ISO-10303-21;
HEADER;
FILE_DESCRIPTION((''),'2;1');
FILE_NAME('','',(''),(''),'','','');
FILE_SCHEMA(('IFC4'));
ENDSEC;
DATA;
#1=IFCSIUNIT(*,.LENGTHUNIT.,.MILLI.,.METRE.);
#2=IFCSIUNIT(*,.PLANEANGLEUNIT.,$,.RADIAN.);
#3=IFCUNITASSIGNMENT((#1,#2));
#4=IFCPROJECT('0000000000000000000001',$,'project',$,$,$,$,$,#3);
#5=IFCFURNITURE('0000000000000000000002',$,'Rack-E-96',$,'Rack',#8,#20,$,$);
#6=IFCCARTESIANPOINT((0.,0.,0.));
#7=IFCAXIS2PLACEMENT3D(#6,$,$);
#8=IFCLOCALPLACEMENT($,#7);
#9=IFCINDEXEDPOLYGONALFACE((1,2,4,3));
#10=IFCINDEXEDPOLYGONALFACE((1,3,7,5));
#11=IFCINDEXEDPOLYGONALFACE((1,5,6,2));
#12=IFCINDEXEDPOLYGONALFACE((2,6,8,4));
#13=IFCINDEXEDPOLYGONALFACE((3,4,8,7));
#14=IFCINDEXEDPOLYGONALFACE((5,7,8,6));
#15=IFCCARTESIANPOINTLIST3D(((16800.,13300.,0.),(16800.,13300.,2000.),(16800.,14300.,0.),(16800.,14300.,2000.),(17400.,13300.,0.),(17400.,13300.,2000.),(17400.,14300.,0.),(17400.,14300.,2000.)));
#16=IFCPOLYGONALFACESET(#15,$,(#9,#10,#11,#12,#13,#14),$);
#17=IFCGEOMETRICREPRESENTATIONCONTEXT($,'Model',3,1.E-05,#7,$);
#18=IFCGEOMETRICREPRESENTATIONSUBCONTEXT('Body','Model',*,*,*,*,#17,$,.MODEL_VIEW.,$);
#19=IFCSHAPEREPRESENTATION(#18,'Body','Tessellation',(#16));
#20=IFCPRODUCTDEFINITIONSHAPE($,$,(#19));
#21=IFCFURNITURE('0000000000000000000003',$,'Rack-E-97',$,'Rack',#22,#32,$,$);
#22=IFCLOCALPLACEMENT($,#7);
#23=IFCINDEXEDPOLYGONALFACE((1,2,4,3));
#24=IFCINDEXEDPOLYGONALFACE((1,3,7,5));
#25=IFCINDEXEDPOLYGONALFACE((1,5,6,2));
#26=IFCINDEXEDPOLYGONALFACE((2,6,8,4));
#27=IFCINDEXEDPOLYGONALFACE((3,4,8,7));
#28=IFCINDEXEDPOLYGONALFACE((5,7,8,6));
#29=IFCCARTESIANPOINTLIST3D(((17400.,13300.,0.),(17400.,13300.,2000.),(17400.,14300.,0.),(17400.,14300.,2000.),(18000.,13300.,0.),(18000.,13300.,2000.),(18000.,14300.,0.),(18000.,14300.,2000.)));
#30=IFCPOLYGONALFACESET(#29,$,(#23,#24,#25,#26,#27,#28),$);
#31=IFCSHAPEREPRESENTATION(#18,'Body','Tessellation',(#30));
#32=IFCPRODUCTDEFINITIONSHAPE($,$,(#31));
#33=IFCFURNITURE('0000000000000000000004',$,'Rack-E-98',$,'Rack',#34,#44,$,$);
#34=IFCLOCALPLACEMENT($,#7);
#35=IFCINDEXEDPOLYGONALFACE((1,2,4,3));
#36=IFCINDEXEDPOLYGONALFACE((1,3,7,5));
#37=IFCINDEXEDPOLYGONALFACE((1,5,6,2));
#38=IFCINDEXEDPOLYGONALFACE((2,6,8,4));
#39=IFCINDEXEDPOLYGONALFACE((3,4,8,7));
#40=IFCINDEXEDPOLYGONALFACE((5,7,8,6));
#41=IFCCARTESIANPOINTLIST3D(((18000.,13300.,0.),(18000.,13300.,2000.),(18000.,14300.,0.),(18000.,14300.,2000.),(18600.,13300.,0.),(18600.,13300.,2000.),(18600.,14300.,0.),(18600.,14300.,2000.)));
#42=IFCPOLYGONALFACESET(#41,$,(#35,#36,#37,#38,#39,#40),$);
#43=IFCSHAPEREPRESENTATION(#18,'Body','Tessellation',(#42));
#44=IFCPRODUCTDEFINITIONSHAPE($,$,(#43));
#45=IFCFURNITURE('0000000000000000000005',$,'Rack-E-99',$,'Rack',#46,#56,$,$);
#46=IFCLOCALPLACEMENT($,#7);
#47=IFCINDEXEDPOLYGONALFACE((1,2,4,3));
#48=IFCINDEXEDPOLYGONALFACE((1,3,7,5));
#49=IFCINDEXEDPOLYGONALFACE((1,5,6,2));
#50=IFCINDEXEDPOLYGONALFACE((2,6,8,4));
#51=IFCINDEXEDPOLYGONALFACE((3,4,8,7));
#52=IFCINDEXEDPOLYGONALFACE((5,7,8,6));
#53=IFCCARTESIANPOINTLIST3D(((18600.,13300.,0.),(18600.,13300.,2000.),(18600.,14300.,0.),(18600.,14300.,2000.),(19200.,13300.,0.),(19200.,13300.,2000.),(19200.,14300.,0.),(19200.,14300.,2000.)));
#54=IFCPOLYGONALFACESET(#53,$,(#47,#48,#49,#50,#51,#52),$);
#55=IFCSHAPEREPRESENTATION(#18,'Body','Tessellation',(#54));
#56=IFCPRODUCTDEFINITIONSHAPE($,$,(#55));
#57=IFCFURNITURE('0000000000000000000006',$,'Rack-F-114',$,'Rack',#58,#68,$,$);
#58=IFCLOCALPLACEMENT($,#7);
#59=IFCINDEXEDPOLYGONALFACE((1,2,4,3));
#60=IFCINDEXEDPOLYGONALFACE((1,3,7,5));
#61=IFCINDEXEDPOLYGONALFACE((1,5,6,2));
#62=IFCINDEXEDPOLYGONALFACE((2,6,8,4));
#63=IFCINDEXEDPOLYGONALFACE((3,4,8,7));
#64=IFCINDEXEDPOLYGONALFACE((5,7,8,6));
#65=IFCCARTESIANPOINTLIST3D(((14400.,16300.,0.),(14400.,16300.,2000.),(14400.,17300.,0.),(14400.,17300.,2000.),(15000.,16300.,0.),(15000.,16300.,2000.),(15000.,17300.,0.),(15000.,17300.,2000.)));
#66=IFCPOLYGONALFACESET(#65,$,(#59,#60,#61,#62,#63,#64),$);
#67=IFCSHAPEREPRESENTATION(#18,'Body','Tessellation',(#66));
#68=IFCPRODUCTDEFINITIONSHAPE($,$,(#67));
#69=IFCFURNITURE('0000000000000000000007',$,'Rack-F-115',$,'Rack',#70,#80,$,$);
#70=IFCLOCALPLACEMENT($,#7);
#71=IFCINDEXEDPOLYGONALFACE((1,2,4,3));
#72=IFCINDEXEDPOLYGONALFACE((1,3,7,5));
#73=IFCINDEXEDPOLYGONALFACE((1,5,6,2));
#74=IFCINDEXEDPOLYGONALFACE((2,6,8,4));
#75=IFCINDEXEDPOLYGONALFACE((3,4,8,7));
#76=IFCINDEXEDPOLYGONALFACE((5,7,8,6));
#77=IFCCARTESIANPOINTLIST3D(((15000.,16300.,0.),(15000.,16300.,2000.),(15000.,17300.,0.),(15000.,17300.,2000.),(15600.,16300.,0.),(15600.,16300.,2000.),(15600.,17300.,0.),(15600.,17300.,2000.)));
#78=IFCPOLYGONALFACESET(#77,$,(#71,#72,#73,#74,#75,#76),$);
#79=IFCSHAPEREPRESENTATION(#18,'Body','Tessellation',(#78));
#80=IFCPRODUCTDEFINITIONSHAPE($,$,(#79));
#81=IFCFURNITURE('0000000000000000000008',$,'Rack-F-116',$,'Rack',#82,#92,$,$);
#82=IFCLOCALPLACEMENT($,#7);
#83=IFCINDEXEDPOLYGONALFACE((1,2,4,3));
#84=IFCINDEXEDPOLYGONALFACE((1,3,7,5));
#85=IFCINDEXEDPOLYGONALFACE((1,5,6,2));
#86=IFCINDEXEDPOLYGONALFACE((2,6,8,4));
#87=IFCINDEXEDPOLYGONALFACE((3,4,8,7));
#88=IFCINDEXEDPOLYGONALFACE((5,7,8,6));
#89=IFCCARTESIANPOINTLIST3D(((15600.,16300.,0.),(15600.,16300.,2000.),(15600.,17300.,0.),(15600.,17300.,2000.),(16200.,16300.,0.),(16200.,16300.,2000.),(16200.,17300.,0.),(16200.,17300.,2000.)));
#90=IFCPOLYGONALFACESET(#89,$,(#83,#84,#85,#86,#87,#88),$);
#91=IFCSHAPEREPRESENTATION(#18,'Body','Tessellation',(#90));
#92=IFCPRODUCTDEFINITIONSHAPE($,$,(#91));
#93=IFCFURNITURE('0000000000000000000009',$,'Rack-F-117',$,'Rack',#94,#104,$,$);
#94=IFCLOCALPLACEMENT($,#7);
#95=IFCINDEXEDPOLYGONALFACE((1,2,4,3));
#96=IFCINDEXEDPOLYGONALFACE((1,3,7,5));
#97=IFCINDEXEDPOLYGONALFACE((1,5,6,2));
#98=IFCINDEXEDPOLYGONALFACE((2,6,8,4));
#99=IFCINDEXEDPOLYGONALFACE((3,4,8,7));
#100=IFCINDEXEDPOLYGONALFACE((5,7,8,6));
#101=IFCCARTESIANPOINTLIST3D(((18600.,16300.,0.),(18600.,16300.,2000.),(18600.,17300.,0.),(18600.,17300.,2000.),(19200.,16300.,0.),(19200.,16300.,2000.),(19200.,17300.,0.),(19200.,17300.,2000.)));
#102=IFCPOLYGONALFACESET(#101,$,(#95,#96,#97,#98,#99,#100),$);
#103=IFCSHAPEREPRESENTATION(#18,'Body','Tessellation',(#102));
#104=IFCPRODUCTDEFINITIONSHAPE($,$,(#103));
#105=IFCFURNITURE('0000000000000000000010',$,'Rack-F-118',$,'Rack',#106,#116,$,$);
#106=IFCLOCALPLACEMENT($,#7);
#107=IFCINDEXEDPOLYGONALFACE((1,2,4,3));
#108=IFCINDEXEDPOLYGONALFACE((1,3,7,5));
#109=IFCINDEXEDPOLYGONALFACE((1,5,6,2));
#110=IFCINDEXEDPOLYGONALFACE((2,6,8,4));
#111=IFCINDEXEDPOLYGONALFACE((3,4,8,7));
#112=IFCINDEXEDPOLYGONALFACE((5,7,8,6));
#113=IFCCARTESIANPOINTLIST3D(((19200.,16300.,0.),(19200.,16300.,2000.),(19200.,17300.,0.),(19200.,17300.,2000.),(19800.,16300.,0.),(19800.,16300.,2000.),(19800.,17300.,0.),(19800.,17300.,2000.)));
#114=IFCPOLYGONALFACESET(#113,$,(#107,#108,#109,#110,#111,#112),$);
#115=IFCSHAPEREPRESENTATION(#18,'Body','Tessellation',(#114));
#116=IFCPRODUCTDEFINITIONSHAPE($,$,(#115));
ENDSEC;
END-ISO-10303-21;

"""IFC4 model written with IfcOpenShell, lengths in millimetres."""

from ifc_helpers import new_model, si_unit, frame, origin, place, context, subcontext, project, rectangle, extrude, element, save


model = new_model("IFC4")

# Units and contexts
model_context = context("Model", 3, precision=1e-05, world=origin())
body_context = subcontext(model_context, "Body", "Model", "MODEL_VIEW")
ifc_project = project(units=[si_unit("LENGTHUNIT", "METRE", prefix="MILLI"), si_unit("PLANEANGLEUNIT", "RADIAN")])

# Furniture
for number, where, name in (
    (1, (17100.0, 13800.0, 0.0), "Rack-E-96"),
    (2, (17700.0, 13800.0, 0.0), "Rack-E-97"),
    (3, (18300.0, 13800.0, 0.0), "Rack-E-98"),
    (4, (18900.0, 13800.0, 0.0), "Rack-E-99"),
    (5, (14700.0, 16800.0, 0.0), "Rack-F-114"),
    (6, (15300.0, 16800.0, 0.0), "Rack-F-115"),
    (7, (15900.0, 16800.0, 0.0), "Rack-F-116"),
    (8, (18900.0, 16800.0, 0.0), "Rack-F-117"),
    (9, (19500.0, 16800.0, 0.0), "Rack-F-118"),
):
    element("IfcFurniture", number, at=place(None, frame(where)), Name=name, ObjectType="Rack", context=body_context, shape_type="SweptSolid", body=[
        extrude(rectangle(XDim=600.0, YDim=1000.0), None, (0.0, 0.0, 1.0), 2000.0),
    ])

save(model, "model.ifc")
